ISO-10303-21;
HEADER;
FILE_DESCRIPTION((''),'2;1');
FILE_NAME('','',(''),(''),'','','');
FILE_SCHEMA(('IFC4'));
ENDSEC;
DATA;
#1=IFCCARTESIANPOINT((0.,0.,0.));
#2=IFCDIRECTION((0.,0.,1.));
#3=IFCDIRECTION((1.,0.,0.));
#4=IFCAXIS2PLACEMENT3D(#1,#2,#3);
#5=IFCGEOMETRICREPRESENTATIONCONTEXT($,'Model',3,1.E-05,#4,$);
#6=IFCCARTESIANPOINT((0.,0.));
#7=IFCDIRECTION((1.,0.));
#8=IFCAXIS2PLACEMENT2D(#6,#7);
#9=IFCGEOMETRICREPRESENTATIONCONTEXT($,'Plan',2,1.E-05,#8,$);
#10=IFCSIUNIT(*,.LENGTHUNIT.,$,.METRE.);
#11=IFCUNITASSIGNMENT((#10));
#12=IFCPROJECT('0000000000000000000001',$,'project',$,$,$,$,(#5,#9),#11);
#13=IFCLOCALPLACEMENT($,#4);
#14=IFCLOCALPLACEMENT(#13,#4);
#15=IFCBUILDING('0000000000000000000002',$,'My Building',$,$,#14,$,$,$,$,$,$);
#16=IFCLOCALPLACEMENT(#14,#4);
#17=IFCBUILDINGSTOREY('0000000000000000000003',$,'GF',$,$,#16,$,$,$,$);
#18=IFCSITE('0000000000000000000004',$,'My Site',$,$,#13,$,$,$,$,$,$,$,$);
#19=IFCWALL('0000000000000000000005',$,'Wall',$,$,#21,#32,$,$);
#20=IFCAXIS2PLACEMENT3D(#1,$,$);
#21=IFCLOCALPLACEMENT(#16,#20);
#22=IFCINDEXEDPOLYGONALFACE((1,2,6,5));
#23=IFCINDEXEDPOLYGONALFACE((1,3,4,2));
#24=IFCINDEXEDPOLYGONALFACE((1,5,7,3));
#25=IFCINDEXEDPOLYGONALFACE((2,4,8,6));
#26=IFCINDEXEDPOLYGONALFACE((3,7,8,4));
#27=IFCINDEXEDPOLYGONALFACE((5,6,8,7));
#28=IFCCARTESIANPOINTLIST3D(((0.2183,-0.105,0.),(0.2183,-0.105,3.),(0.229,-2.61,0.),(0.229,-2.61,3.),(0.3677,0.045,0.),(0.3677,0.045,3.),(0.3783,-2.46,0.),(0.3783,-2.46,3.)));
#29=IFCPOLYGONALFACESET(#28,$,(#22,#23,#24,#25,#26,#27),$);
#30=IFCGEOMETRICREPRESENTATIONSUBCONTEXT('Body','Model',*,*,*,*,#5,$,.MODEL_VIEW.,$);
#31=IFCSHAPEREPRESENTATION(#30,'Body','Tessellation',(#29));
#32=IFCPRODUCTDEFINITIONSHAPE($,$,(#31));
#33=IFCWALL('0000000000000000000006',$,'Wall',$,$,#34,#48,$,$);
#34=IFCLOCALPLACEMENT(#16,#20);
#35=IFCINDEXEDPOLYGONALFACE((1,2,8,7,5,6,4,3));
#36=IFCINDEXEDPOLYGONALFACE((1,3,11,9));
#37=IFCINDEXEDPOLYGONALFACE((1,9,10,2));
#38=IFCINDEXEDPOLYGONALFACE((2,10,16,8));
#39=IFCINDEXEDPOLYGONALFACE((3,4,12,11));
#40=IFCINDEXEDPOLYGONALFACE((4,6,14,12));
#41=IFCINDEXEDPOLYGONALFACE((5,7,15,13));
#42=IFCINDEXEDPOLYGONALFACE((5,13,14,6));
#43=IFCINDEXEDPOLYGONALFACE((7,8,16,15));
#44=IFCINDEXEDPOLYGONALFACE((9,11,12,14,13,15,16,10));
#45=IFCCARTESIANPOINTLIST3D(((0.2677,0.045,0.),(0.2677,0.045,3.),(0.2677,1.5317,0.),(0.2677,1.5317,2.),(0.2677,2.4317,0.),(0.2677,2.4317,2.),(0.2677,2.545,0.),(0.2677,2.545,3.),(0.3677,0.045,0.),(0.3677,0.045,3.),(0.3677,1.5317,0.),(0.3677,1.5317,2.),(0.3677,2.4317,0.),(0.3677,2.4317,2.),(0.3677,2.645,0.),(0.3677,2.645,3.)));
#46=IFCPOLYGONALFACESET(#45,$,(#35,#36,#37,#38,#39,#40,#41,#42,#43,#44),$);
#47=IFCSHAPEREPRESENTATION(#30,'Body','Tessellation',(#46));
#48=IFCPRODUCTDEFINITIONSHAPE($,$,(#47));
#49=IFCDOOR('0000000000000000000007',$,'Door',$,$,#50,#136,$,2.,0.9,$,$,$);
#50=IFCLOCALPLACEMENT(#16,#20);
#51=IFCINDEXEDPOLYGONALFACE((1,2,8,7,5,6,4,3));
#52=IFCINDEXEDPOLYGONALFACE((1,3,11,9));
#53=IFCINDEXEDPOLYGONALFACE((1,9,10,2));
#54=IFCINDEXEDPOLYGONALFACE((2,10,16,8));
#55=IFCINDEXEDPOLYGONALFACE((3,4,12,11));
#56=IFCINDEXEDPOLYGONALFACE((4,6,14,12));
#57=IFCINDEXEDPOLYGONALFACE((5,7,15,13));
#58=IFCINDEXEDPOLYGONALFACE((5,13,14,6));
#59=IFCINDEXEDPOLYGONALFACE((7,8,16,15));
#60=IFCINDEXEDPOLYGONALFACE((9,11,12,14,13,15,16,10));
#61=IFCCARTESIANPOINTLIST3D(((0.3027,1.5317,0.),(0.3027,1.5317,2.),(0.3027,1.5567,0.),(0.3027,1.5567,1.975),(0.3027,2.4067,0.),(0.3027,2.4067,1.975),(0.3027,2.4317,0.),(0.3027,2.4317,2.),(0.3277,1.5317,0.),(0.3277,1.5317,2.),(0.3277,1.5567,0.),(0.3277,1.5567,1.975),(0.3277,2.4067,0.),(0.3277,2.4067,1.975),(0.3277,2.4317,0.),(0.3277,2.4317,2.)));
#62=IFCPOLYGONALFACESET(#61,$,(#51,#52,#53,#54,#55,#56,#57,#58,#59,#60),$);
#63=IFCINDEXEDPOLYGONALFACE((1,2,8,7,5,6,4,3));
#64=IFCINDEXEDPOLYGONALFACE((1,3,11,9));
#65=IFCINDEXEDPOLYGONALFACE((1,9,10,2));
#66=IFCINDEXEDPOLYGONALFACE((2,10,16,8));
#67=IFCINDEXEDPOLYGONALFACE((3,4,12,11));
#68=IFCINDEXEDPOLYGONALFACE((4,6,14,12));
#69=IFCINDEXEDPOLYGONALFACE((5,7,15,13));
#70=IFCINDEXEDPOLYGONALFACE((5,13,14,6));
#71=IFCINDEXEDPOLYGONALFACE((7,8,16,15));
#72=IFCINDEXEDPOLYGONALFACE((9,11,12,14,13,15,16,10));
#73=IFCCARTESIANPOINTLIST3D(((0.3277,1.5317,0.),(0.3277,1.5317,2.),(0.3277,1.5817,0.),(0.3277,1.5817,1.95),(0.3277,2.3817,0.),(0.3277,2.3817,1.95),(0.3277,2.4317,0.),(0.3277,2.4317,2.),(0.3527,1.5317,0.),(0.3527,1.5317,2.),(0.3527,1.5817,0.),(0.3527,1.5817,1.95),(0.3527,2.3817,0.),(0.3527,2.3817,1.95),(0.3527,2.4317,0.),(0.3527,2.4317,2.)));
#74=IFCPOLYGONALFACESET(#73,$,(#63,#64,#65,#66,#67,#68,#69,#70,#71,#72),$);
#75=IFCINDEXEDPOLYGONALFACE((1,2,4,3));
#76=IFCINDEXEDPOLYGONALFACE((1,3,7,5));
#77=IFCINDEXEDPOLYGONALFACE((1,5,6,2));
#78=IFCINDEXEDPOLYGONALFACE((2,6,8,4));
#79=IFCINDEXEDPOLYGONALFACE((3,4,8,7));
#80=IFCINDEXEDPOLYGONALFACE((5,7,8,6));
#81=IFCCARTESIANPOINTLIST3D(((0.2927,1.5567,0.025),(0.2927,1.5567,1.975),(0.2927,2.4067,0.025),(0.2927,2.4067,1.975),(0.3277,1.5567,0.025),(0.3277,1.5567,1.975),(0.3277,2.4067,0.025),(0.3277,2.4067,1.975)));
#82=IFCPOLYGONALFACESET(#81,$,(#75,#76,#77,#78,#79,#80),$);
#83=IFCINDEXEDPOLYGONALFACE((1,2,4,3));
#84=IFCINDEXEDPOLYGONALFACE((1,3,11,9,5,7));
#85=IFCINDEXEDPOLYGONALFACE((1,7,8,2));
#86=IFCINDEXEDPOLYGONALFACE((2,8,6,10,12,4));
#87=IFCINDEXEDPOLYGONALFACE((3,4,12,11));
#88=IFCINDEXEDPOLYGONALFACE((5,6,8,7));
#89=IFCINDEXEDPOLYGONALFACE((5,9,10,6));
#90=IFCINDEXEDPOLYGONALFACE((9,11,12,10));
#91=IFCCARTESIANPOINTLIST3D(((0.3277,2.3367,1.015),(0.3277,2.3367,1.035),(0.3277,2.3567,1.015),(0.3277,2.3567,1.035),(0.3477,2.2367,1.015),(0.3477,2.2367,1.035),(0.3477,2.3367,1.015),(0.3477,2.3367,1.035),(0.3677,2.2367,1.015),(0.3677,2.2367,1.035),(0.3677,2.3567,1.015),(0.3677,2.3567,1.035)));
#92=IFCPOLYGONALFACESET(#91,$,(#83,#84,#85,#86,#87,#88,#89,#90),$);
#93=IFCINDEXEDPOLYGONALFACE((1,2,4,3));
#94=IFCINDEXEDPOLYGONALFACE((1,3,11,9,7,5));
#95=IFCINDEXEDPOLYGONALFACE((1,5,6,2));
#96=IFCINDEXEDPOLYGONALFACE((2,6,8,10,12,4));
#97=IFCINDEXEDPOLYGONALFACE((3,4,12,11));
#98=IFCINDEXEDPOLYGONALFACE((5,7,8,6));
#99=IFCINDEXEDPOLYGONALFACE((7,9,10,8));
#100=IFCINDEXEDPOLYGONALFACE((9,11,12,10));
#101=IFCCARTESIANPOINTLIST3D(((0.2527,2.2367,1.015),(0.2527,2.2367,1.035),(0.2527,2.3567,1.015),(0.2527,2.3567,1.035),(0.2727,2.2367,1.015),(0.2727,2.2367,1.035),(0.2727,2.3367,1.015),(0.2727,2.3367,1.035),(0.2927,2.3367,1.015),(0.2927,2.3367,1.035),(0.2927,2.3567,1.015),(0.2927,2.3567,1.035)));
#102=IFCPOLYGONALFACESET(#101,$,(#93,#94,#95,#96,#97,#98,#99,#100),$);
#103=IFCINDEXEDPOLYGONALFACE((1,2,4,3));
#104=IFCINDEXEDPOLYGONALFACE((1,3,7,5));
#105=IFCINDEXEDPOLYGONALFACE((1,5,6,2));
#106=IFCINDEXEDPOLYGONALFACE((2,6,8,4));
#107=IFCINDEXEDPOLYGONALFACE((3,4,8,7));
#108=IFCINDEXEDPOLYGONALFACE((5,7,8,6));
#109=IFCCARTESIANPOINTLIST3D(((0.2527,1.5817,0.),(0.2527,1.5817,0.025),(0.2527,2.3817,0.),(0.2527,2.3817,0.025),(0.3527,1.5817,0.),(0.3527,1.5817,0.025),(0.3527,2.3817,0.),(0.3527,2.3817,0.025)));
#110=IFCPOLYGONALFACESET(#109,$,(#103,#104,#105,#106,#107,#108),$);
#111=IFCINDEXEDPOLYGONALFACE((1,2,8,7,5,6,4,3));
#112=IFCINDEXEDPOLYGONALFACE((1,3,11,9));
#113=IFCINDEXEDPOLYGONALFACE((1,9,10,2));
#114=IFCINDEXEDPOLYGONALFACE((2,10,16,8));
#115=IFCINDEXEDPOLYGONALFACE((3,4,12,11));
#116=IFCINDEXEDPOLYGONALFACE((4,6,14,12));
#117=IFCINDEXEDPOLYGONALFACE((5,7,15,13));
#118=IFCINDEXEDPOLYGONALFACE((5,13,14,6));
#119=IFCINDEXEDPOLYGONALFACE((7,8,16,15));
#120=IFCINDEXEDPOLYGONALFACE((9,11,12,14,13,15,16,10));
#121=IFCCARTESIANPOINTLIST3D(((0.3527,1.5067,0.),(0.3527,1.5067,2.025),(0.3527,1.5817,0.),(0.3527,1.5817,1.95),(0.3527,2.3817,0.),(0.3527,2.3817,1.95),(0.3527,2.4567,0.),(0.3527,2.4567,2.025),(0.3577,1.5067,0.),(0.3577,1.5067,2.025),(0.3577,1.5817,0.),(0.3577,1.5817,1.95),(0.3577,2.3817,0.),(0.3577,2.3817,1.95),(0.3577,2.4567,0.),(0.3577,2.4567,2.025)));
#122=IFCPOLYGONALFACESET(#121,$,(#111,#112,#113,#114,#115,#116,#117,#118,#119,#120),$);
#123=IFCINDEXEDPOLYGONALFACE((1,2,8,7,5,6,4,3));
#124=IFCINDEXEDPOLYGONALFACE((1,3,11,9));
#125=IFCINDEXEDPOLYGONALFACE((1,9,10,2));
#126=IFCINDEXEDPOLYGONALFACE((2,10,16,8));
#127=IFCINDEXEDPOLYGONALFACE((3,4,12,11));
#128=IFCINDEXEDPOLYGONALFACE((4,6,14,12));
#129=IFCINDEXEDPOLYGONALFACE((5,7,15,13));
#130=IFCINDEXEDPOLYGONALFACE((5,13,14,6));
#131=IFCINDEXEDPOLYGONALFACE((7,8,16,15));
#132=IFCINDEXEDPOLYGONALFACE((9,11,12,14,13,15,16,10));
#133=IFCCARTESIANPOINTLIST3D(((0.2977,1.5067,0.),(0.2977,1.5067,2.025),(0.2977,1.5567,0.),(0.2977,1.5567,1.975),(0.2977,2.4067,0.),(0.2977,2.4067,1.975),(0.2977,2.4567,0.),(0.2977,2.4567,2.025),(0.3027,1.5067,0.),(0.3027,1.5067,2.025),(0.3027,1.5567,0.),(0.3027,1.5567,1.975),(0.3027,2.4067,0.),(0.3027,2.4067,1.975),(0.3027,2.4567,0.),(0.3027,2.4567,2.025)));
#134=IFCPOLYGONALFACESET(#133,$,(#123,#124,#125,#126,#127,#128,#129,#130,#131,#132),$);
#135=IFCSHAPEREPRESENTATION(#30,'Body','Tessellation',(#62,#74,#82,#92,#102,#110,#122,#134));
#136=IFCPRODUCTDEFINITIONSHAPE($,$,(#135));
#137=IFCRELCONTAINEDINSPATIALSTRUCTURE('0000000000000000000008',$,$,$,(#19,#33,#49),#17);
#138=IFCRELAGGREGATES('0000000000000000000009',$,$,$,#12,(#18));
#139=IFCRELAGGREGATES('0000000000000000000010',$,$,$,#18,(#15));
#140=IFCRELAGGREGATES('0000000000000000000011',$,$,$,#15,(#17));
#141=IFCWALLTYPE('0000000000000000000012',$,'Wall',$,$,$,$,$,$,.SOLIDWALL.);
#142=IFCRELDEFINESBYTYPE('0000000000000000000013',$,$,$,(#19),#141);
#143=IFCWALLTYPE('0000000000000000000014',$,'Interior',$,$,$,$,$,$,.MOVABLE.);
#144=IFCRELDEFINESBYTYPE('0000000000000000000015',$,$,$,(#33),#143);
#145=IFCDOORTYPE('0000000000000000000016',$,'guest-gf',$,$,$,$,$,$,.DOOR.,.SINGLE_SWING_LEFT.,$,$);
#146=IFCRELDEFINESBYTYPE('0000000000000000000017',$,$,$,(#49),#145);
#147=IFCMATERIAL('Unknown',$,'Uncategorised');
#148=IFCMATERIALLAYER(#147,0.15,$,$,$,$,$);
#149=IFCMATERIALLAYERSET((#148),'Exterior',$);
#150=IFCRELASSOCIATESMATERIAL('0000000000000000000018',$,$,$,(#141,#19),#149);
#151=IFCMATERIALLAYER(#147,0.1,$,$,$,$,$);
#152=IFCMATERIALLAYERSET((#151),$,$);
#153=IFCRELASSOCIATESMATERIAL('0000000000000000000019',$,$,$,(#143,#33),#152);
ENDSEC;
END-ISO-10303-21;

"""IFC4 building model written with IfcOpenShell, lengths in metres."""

from ifc_helpers import new_model, entity, si_unit, frame, origin_with_axes, origin_2d_with_axis, place, context, subcontext, project, spatial, line, indexed_curve, outline, extrude, shape, source, transform, mapped, material, layer, layer_set, layer_usage, type_object, type_shapes, element, fill, save


model = new_model("IFC4")

# Units and contexts
model_context = context("Model", 3, precision=1e-05, world=origin_with_axes())
plan_context = context("Plan", 2, precision=1e-05, world=origin_2d_with_axis())
body_context_1 = subcontext(model_context, "Body", "Model", "MODEL_VIEW")
body_context_2 = subcontext(plan_context, "Body", "Plan", "PLAN_VIEW")
ifc_project = project(units=[si_unit("LENGTHUNIT", "METRE")], contexts=[model_context, plan_context])

# Site, building, storey
site_placement = place(None, origin_with_axes())
site = spatial("IfcSite", under=ifc_project, at=site_placement, Name="My Site")
building_placement = place(site_placement, origin_with_axes())
building = spatial("IfcBuilding", under=site, at=building_placement, Name="My Building")
storey_placement = place(building_placement, origin_with_axes())
storey = spatial("IfcBuildingStorey", under=building, at=storey_placement, Name="GF")

# Shared definitions
ifc_material = material(Name="Unknown", Category="Uncategorised")

# Shared definitions
ifc_layer_1 = layer(ifc_material, 0.15)
ifc_layer_set_1 = layer_set([ifc_layer_1], Name="Exterior")
wall_type_1 = type_object("IfcWallType", Name="Wall", PredefinedType="SOLIDWALL", material=ifc_layer_set_1)

# Wall
ifc_layer_usage_1 = layer_usage(ifc_layer_set_1, "AXIS2", "POSITIVE", 0.0)
wall_1_placement = place(storey_placement, frame((0.2183, -0.105, 0.0), z_axis=(0.0, 0.0, 1.0), x_axis=(0.004245, -0.999991, 0.0)))
element("IfcWall", 1, at=wall_1_placement, inside=storey, type_object=wall_type_1, material=ifc_layer_usage_1, Name="Wall", context=body_context_1, shape_type="SweptSolid", body=[
    extrude(outline(indexed_curve([(0.0, 0.0), (-0.1494, 0.15), (2.3557, 0.15), (2.505, 0.0)], segments=[line(1, 2, 3, 4, 1)])), origin_with_axes(), (0.0, 0.0, 1.0), 3.0),
])

# Wall, opening, door
ifc_layer_2 = layer(ifc_material, 0.1)
ifc_layer_set_2 = layer_set([ifc_layer_2])
ifc_layer_usage_2 = layer_usage(ifc_layer_set_2, "AXIS2", "POSITIVE", 0.0)
wall_type_2 = type_object("IfcWallType", Name="Interior", PredefinedType="MOVABLE", material=ifc_layer_set_2)
wall_2_placement = place(storey_placement, frame((0.3677, 0.045, 0.0), z_axis=(0.0, 0.0, 1.0), x_axis=(0.0, 1.0, 0.0)))
wall_2 = element("IfcWall", 2, at=wall_2_placement, inside=storey, type_object=wall_type_2, material=ifc_layer_usage_2, Name="Wall", context=body_context_1, shape_type="SweptSolid", body=[
    extrude(outline(indexed_curve([(0.0, 0.0), (0.0, 0.1), (2.5, 0.1), (2.6, 0.0)], segments=[line(1, 2, 3, 4, 1)])), origin_with_axes(), (0.0, 0.0, 1.0), 3.0),
])
shared_shape_1 = source(origin_with_axes(), body_context_1, "Body", "SweptSolid", [
    extrude(outline(indexed_curve([(0.0, 0.0), (0.9, 0.0), (0.9, 2.0), (0.0, 2.0)], segments=[line(1, 2, 3, 4, 1)])), frame((0.0, -0.6, 0.0), z_axis=(0.0, -1.0, 0.0), x_axis=(1.0, 0.0, 0.0)), (0.0, 0.0, -1.0), 1.2),
])
opening_1_placement = place(wall_2_placement, frame((1.4867, 0.015, 0.0), z_axis=(0.0, 0.0, 1.0), x_axis=(1.0, 0.0, 0.0)))
opening_1 = element("IfcOpeningElement", 3, at=opening_1_placement, cuts=wall_2, PredefinedType="OPENING", context=body_context_1, shape_type="MappedRepresentation", body=[
    mapped(shared_shape_1, transform((0.0, 0.0, 0.0), x_axis=(1.0, 0.0, 0.0), y_axis=(0.0, 1.0, 0.0), z_axis=(0.0, 0.0, 1.0), scale=1.0)),
])
door_type_1 = type_object("IfcDoorType", Name="guest-gf", OperationType="SINGLE_SWING_LEFT", PredefinedType="DOOR")
shared_shape_2 = source(origin_with_axes(), body_context_1, "Body", "SweptSolid", [
    extrude(outline(indexed_curve([(0.0, 0.0), (0.0, 2.0), (0.9, 2.0), (0.9, 0.0), (0.875, 0.0), (0.875, 1.975), (0.025, 1.975), (0.025, 0.0)], segments=[line(1, 2, 3, 4, 5, 6, 7, 8, 1)])), frame((0.0, 0.025, 0.0), z_axis=(0.0, -1.0, 0.0), x_axis=(1.0, 0.0, 0.0)), (0.0, 0.0, -1.0), 0.025),
    extrude(outline(indexed_curve([(0.0, 0.0), (0.0, 2.0), (0.9, 2.0), (0.9, 0.0), (0.85, 0.0), (0.85, 1.95), (0.05, 1.95), (0.05, 0.0)], segments=[line(1, 2, 3, 4, 5, 6, 7, 8, 1)])), frame((0.0, 0.0, 0.0), z_axis=(0.0, -1.0, 0.0), x_axis=(1.0, 0.0, 0.0)), (0.0, 0.0, -1.0), 0.025),
    extrude(outline(indexed_curve([(0.0, 0.0), (0.85, 0.0), (0.85, 0.035), (0.0, 0.035)], segments=[line(1, 2, 3, 4, 1)])), frame((0.025, 0.025, 0.025), z_axis=(0.0, 0.0, 1.0), x_axis=(1.0, 0.0, 0.0)), (0.0, 0.0, 1.0), 1.95),
    extrude(outline(indexed_curve([(0.0, 0.0), (0.0, -0.04), (-0.12, -0.04), (-0.12, -0.02), (-0.02, -0.02), (-0.02, 0.0)], segments=[line(1, 2, 3, 4, 5, 6, 1)])), frame((0.825, 0.025, 1.015), z_axis=(0.0, 0.0, 1.0), x_axis=(1.0, 0.0, 0.0)), (0.0, 0.0, 1.0), 0.02),
    extrude(outline(indexed_curve([(0.0, 0.0), (0.0, 0.04), (-0.12, 0.04), (-0.12, 0.02), (-0.02, 0.02), (-0.02, 0.0)], segments=[line(1, 2, 3, 4, 5, 6, 1)])), frame((0.825, 0.06, 1.015), z_axis=(0.0, 0.0, 1.0), x_axis=(1.0, 0.0, 0.0)), (0.0, 0.0, 1.0), 0.02),
    extrude(outline(indexed_curve([(0.0, 0.0), (0.8, 0.0), (0.8, 0.1), (0.0, 0.1)], segments=[line(1, 2, 3, 4, 1)])), frame((0.05, 0.0, 0.0), z_axis=(0.0, 0.0, 1.0), x_axis=(1.0, 0.0, 0.0)), (0.0, 0.0, 1.0), 0.025),
    extrude(outline(indexed_curve([(0.0, 0.0), (0.0, 2.025), (0.95, 2.025), (0.95, 0.0), (0.875, 0.0), (0.875, 1.95), (0.075, 1.95), (0.075, 0.0)], segments=[line(1, 2, 3, 4, 5, 6, 7, 8, 1)])), frame((-0.025, -0.005, 0.0), z_axis=(0.0, -1.0, 0.0), x_axis=(1.0, 0.0, 0.0)), (0.0, 0.0, -1.0), 0.005),
    extrude(outline(indexed_curve([(0.0, 0.0), (0.0, 2.025), (0.95, 2.025), (0.95, 0.0), (0.9, 0.0), (0.9, 1.975), (0.05, 1.975), (0.05, 0.0)], segments=[line(1, 2, 3, 4, 5, 6, 7, 8, 1)])), frame((-0.025, 0.05, 0.0), z_axis=(0.0, -1.0, 0.0), x_axis=(1.0, 0.0, 0.0)), (0.0, 0.0, -1.0), 0.005),
])
shared_shape_3 = source(origin_with_axes(), body_context_2, "Body", "Curve2D", [
    entity("IfcIndexedPolyCurve", entity("IfcCartesianPointList2D", [[0.0, 0.0], [0.0, 0.05], [0.025, 0.05], [0.025, 0.025], [0.05, 0.025], [0.05, 0.0]]), [entity("IfcLineIndex", [1, 2, 3, 4, 5, 6, 1])]),
    entity("IfcIndexedPolyCurve", entity("IfcCartesianPointList2D", [[0.9, 0.0], [0.9, 0.05], [0.875, 0.05], [0.875, 0.025], [0.85, 0.025], [0.85, 0.0]]), [entity("IfcLineIndex", [1, 2, 3, 4, 5, 6, 1])]),
    entity("IfcTrimmedCurve", entity("IfcEllipse", entity("IfcAxis2Placement2D", entity("IfcCartesianPoint", [0.06, 0.05]), entity("IfcDirection", [1.0, 0.0])), 0.815, 0.85), [entity("IfcCartesianPoint", [0.875, 0.05])], [entity("IfcCartesianPoint", [0.06, 0.9])], True, "CARTESIAN"),
    entity("IfcIndexedPolyCurve", entity("IfcCartesianPointList2D", [[0.025, 0.05], [0.06, 0.05], [0.06, 0.9], [0.025, 0.9]]), [entity("IfcLineIndex", [1, 2, 3, 4, 1])]),
])
type_shapes(door_type_1, [shared_shape_2, shared_shape_3])
door_1_placement = place(opening_1_placement, frame((0.0, 0.0, 0.0), z_axis=(0.0, 0.0, 1.0), x_axis=(1.0, 0.0, 0.0)))
door_1 = element("IfcDoor", 4, at=door_1_placement, inside=storey, type_object=door_type_1, Name="Door", OverallHeight=2.0, OverallWidth=0.9, shapes=[
    shape(body_context_1, "Body", "MappedRepresentation", [mapped(shared_shape_2, transform((0.0, 0.0, 0.0), x_axis=(1.0, 0.0, 0.0), y_axis=(0.0, 1.0, 0.0), z_axis=(0.0, 0.0, 1.0), scale=1.0))]),
    shape(body_context_2, "Body", "MappedRepresentation", [mapped(shared_shape_3, transform((0.0, 0.0, 0.0), x_axis=(1.0, 0.0, 0.0), y_axis=(0.0, 1.0, 0.0), z_axis=(0.0, 0.0, 1.0), scale=1.0))]),
])
fill(opening_1, door_1)

save(model, "model.ifc")
